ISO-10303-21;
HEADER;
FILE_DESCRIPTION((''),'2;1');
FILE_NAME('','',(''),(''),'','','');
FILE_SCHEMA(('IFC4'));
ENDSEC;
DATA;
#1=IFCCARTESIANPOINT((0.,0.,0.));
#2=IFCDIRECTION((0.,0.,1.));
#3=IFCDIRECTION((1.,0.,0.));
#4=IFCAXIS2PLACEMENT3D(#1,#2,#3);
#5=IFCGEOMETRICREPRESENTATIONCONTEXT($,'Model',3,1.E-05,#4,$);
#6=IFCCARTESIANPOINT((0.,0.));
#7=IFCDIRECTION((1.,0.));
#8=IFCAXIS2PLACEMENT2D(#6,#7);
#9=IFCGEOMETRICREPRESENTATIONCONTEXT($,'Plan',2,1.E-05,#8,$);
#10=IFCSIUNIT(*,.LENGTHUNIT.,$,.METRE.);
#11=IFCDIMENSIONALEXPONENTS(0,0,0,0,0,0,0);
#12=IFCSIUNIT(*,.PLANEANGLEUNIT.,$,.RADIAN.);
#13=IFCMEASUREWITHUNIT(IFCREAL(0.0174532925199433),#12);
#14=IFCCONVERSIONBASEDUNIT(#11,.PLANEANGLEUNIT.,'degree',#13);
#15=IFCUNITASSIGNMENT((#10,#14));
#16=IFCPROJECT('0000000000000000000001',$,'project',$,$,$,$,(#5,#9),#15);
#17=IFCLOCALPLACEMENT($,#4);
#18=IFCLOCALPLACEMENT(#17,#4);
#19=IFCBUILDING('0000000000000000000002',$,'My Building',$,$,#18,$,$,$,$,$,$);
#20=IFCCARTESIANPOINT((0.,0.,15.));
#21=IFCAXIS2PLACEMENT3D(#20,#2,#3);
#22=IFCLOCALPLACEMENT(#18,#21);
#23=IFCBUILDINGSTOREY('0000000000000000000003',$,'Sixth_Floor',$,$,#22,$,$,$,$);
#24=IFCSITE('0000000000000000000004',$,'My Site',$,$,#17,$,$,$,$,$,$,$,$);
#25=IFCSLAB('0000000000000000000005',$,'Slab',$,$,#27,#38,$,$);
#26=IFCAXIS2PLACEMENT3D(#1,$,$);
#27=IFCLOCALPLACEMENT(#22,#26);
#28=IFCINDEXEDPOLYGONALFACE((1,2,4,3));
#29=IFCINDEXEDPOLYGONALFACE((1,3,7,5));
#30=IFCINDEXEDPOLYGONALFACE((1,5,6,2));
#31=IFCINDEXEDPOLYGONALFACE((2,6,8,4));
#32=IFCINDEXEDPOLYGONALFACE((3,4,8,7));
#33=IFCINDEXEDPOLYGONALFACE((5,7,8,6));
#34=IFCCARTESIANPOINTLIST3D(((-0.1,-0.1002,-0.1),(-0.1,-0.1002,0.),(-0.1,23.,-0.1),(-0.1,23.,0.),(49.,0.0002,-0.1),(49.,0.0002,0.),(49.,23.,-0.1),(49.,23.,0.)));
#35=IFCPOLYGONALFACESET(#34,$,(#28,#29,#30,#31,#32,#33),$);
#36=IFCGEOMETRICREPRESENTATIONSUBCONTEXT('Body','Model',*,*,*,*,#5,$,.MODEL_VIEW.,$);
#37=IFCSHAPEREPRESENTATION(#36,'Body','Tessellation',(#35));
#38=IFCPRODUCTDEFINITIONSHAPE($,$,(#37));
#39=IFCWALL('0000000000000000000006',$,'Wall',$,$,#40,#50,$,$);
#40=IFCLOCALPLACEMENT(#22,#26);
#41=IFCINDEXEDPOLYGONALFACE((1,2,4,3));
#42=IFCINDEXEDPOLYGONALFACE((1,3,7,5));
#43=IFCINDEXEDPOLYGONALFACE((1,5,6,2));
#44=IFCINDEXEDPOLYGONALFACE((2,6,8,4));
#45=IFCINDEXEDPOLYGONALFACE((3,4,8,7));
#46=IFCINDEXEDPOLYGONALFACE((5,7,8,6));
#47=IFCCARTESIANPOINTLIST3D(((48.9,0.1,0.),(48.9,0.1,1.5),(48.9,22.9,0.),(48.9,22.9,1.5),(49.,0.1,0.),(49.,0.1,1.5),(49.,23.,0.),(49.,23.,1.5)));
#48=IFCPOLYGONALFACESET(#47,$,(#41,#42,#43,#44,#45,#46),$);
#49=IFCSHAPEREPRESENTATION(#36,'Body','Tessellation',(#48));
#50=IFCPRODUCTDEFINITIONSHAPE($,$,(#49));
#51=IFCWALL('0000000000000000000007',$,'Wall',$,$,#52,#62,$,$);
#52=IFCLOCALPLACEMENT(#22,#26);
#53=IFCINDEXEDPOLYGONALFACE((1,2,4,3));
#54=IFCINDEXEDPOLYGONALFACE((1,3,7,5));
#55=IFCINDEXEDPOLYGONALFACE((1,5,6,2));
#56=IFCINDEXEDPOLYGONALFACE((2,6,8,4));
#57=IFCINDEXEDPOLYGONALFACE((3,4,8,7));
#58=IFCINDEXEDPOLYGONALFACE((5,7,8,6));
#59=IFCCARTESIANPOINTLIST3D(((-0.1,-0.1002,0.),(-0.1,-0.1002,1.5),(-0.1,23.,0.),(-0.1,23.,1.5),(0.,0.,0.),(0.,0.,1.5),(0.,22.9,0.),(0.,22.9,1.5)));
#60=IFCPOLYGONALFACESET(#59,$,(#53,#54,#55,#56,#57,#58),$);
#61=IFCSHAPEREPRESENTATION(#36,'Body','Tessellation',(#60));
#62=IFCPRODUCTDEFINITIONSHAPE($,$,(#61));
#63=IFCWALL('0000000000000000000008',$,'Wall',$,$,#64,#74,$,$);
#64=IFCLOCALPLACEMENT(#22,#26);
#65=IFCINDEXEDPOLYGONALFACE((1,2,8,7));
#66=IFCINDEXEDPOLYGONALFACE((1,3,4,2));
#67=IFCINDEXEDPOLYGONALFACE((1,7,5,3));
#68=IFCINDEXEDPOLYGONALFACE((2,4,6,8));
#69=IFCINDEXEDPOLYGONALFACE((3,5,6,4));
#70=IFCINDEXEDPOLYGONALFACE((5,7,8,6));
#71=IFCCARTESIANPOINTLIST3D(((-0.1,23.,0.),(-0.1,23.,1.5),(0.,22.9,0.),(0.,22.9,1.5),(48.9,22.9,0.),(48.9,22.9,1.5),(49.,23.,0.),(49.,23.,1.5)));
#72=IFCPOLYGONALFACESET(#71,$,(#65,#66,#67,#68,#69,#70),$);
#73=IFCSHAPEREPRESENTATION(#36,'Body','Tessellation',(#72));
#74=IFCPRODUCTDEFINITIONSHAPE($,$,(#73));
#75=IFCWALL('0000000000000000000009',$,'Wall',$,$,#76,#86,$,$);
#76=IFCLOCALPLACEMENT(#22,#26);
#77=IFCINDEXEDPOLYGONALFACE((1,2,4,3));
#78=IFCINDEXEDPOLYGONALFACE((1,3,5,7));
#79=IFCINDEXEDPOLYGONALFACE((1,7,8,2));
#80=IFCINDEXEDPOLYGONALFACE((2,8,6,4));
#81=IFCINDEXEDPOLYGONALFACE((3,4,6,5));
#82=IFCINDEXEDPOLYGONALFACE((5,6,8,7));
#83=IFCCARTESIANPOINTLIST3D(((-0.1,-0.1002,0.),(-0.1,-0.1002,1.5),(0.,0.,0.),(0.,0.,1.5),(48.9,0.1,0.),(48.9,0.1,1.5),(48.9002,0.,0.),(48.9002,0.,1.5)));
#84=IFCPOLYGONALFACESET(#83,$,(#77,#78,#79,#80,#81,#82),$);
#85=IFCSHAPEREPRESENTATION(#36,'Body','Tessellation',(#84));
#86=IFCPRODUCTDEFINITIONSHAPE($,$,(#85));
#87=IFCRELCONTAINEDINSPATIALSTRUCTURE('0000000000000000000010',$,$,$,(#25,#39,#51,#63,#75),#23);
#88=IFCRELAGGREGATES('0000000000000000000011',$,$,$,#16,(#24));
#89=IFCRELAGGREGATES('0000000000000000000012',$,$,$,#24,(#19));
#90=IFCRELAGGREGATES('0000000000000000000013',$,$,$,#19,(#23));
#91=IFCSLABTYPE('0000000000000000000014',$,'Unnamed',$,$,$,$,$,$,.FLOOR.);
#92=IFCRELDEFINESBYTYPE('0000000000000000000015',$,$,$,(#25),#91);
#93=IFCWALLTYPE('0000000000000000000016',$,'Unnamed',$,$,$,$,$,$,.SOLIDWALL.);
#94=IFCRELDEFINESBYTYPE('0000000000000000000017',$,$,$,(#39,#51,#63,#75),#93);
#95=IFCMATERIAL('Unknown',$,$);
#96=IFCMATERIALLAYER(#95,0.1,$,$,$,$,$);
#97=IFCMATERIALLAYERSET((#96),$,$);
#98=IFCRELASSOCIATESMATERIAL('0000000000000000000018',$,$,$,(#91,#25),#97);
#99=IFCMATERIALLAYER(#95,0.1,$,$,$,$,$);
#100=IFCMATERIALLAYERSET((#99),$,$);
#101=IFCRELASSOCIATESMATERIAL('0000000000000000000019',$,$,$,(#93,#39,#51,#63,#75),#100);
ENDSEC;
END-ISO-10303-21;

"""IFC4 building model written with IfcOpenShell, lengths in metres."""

from ifc_helpers import new_model, entity, si_unit, converted_unit, frame, origin_with_axes, origin_2d_with_axis, place, context, subcontext, project, spatial, line, indexed_curve, outline, extrude, material, layer, layer_set, layer_usage, type_object, element, save


model = new_model("IFC4")

# Units and contexts
model_context = context("Model", 3, precision=1e-05, world=origin_with_axes())
plan_context = context("Plan", 2, precision=1e-05, world=origin_2d_with_axis())
body_context = subcontext(model_context, "Body", "Model", "MODEL_VIEW")
ifc_project = project(units=[si_unit("LENGTHUNIT", "METRE"), converted_unit("PLANEANGLEUNIT", "degree", entity("IfcReal", 0.0174532925199433), si_unit("PLANEANGLEUNIT", "RADIAN"), dimensions=[0, 0, 0, 0, 0, 0, 0])], contexts=[model_context, plan_context])

# Site, building, storey
site_placement = place(None, origin_with_axes())
site = spatial("IfcSite", under=ifc_project, at=site_placement, Name="My Site")
building_placement = place(site_placement, origin_with_axes())
building = spatial("IfcBuilding", under=site, at=building_placement, Name="My Building")
storey_placement = place(building_placement, frame((0.0, 0.0, 15.0), z_axis=(0.0, 0.0, 1.0), x_axis=(1.0, 0.0, 0.0)))
storey = spatial("IfcBuildingStorey", under=building, at=storey_placement, Name="Sixth_Floor")

# Slab
ifc_material = material(Name="Unknown")
ifc_layer_1 = layer(ifc_material, 0.1)
ifc_layer_set_1 = layer_set([ifc_layer_1])
ifc_layer_usage_1 = layer_usage(ifc_layer_set_1, "AXIS3", "POSITIVE", -0.1)
slab_type = type_object("IfcSlabType", Name="Unnamed", PredefinedType="FLOOR", material=ifc_layer_set_1)
slab_placement = place(storey_placement, frame((-0.1, 23.0, 0.0), z_axis=(0.0, 0.0, 1.0), x_axis=(1.0, 0.0, 0.0)))
element("IfcSlab", 1, at=slab_placement, inside=storey, type_object=slab_type, material=ifc_layer_usage_1, Name="Slab", context=body_context, shape_type="SweptSolid", body=[
    extrude(outline(indexed_curve([(0.0, -23.1002), (49.1, -22.9998), (49.1, 0.0), (0.0, 0.0), (0.0, -23.1002)])), frame((0.0, 0.0, -0.1), z_axis=(0.0, 0.0, 1.0), x_axis=(1.0, 0.0, 0.0)), (0.0, 0.0, 1.0), 0.1),
])

# Walls
ifc_layer_2 = layer(ifc_material, 0.1)
ifc_layer_set_2 = layer_set([ifc_layer_2])
ifc_layer_usage_2 = layer_usage(ifc_layer_set_2, "AXIS2", "POSITIVE", 0.0)
wall_type = type_object("IfcWallType", Name="Unnamed", PredefinedType="SOLIDWALL", material=ifc_layer_set_2)
wall_1_placement = place(storey_placement, frame((48.9, 22.9, 0.0), z_axis=(0.0, 0.0, 1.0), x_axis=(0.0, -1.0, 0.0)))
element("IfcWall", 2, at=wall_1_placement, inside=storey, type_object=wall_type, material=ifc_layer_usage_2, Name="Wall", context=body_context, shape_type="SweptSolid", body=[
    extrude(outline(indexed_curve([(0.0, 0.0), (-0.1, 0.1), (22.8, 0.1), (22.8, 0.0)], segments=[line(1, 2, 3, 4, 1)])), origin_with_axes(), (0.0, 0.0, 1.0), 1.5),
])
ifc_layer_usage_3 = layer_usage(ifc_layer_set_2, "AXIS2", "POSITIVE", 0.0)
wall_2_placement = place(storey_placement, frame((0.0, 0.0, 0.0), z_axis=(0.0, 0.0, 1.0), x_axis=(0.0, 1.0, 0.0)))
element("IfcWall", 3, at=wall_2_placement, inside=storey, type_object=wall_type, material=ifc_layer_usage_3, Name="Wall", context=body_context, shape_type="SweptSolid", body=[
    extrude(outline(indexed_curve([(0.0, 0.0), (-0.1002, 0.1), (23.0, 0.1), (22.9, 0.0)], segments=[line(1, 2, 3, 4, 1)])), origin_with_axes(), (0.0, 0.0, 1.0), 1.5),
])
ifc_layer_usage_4 = layer_usage(ifc_layer_set_2, "AXIS2", "POSITIVE", 0.0)
wall_3_placement = place(storey_placement, frame((0.0, 22.9, 0.0), z_axis=(0.0, 0.0, 1.0), x_axis=(1.0, 0.0, 0.0)))
element("IfcWall", 4, at=wall_3_placement, inside=storey, type_object=wall_type, material=ifc_layer_usage_4, Name="Wall", context=body_context, shape_type="SweptSolid", body=[
    extrude(outline(indexed_curve([(0.0, 0.0), (-0.1, 0.1), (49.0, 0.1), (48.9, 0.0)], segments=[line(1, 2, 3, 4, 1)])), origin_with_axes(), (0.0, 0.0, 1.0), 1.5),
])
ifc_layer_usage_5 = layer_usage(ifc_layer_set_2, "AXIS2", "POSITIVE", 0.0)
wall_4_placement = place(storey_placement, frame((48.9, 0.1, 0.0), z_axis=(0.0, 0.0, 1.0), x_axis=(-0.999998, -0.002045, 0.0)))
element("IfcWall", 5, at=wall_4_placement, inside=storey, type_object=wall_type, material=ifc_layer_usage_5, Name="Wall", context=body_context, shape_type="SweptSolid", body=[
    extrude(outline(indexed_curve([(0.0, 0.0), (0.0, 0.1), (49.0003, 0.1), (48.9001, 0.0)], segments=[line(1, 2, 3, 4, 1)])), origin_with_axes(), (0.0, 0.0, 1.0), 1.5),
])

save(model, "model.ifc")
